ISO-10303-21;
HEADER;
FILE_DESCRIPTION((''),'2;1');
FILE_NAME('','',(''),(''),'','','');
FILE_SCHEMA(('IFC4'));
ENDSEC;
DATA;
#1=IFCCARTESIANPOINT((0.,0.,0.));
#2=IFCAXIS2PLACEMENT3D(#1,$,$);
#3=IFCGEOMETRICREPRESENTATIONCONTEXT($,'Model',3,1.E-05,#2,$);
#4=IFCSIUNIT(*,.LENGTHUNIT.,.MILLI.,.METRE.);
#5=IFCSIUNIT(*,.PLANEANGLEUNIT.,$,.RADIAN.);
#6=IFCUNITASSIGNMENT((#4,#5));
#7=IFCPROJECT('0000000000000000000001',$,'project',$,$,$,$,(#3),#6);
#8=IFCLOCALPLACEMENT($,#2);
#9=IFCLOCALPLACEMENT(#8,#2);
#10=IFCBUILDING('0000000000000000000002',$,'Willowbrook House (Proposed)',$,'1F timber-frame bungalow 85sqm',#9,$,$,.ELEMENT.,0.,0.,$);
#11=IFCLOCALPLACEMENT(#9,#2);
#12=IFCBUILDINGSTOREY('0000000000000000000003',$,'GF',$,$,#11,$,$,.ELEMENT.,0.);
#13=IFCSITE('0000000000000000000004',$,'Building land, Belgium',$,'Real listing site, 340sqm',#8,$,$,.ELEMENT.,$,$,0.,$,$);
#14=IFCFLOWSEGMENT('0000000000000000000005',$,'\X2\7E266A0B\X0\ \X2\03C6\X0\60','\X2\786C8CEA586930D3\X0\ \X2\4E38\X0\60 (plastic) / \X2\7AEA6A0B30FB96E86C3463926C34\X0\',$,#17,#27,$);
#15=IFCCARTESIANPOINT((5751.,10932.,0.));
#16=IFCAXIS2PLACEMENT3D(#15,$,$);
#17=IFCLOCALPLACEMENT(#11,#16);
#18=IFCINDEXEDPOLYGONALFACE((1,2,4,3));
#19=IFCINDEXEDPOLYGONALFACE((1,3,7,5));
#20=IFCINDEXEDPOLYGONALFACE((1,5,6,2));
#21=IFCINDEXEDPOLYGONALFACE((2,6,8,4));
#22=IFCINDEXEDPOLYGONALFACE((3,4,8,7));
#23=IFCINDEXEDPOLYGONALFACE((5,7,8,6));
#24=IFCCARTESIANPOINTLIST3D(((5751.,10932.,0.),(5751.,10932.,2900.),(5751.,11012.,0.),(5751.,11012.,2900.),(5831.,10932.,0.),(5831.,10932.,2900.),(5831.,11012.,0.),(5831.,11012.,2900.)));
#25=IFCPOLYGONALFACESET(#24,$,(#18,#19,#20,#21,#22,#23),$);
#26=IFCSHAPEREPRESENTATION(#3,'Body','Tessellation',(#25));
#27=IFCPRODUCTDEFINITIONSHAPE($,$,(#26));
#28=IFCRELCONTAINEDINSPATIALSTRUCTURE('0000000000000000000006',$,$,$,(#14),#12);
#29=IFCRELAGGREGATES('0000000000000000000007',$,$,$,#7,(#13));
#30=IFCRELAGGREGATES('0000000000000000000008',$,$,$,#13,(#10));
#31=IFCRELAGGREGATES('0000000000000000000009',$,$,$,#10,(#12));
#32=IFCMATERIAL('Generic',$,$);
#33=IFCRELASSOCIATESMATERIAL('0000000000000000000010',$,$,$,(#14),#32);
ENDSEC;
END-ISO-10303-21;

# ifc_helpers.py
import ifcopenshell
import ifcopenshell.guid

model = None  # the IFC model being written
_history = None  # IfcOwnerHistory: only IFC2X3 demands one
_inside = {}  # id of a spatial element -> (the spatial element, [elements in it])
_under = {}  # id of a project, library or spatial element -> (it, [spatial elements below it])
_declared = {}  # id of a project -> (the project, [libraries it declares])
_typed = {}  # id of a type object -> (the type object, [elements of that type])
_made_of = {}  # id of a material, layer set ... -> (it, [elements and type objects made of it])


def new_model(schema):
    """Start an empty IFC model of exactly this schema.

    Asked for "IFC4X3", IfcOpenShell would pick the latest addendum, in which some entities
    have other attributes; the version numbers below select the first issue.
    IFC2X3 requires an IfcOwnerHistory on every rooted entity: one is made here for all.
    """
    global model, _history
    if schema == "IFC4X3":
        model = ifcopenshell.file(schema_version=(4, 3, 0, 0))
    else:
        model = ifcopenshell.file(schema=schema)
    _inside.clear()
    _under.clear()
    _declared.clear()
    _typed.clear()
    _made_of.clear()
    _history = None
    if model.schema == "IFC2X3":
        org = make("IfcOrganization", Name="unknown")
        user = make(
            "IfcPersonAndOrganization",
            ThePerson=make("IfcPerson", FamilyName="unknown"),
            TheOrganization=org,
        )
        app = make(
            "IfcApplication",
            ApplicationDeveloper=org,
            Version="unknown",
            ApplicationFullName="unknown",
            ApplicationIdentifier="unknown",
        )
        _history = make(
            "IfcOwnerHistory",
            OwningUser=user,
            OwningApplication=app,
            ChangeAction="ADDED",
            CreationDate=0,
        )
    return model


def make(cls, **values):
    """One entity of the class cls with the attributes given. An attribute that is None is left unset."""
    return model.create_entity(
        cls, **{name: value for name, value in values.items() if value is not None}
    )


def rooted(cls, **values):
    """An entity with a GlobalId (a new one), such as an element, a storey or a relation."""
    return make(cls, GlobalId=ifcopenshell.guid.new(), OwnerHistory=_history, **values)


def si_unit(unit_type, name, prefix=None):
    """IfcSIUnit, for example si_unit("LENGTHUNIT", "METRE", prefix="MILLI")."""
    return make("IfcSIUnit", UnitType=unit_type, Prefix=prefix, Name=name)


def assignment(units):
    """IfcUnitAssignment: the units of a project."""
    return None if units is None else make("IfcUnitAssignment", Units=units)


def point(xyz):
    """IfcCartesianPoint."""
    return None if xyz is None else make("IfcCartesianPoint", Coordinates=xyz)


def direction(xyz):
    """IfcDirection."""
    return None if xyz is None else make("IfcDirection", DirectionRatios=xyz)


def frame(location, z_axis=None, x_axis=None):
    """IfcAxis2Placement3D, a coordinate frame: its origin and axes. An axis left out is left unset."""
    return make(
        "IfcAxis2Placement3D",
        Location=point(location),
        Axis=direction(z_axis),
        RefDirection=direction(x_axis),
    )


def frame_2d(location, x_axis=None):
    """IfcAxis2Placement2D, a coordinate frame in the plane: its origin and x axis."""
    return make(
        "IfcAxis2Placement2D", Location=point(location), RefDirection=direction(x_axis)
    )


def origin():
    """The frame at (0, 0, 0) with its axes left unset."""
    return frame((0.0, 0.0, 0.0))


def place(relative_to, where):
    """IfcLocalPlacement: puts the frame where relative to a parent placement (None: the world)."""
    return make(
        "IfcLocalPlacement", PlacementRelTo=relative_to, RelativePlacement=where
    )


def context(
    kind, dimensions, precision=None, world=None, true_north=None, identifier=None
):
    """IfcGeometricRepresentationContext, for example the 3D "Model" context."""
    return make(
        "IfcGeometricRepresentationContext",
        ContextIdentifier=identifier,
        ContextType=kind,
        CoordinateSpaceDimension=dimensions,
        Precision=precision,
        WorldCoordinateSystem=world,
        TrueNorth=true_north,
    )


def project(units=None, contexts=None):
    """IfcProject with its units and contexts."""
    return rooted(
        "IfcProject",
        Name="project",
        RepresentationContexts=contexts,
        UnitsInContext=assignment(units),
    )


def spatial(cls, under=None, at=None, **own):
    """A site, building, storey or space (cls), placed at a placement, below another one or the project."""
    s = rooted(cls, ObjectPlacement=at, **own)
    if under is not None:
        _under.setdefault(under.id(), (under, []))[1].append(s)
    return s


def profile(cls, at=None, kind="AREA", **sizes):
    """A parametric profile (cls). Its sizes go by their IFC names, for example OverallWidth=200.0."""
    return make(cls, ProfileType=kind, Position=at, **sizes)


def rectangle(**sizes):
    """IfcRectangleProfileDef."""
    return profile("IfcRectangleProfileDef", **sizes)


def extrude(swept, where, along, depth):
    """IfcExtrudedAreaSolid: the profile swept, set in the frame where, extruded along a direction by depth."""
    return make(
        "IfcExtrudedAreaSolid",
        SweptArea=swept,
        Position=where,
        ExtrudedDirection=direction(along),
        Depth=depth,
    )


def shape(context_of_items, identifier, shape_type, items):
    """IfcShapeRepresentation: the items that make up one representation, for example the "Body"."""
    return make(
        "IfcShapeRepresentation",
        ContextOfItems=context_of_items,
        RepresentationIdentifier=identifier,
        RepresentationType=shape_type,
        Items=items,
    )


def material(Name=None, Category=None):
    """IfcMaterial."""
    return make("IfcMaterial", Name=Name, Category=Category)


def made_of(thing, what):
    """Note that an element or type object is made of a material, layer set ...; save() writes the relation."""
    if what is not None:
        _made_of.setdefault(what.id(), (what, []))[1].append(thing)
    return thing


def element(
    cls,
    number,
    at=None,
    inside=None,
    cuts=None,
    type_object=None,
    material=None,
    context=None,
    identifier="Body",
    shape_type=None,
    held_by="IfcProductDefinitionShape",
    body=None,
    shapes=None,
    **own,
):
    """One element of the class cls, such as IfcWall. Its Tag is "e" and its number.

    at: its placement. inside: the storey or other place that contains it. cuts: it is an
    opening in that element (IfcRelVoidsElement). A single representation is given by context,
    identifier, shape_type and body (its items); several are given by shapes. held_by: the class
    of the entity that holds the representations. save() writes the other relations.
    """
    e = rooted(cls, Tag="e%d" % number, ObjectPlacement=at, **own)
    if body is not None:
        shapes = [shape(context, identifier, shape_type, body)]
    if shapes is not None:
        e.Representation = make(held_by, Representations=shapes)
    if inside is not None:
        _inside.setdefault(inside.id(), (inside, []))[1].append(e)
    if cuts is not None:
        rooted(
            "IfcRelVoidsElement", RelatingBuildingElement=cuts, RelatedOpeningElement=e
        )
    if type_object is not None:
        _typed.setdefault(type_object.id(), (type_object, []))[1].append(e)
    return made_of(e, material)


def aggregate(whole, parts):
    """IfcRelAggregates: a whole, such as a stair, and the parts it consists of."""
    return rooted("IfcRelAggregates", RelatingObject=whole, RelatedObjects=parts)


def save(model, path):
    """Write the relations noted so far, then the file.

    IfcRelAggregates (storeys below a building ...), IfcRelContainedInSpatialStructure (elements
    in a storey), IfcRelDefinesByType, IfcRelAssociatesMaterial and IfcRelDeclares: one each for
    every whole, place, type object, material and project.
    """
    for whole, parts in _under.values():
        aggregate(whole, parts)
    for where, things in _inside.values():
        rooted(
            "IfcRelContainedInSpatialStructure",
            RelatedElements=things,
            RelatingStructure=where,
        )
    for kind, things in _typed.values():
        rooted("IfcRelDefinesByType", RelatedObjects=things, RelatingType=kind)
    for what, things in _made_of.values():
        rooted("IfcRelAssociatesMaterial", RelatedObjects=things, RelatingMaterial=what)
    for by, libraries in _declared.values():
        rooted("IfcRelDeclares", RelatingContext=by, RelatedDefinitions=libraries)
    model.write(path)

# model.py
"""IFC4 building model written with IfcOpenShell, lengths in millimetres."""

from ifc_helpers import new_model, si_unit, frame, frame_2d, origin, place, context, project, spatial, rectangle, extrude, material, element, save


model = new_model("IFC4")

# Units and contexts
model_context = context("Model", 3, precision=1e-05, world=origin())
ifc_project = project(units=[si_unit("LENGTHUNIT", "METRE", prefix="MILLI"), si_unit("PLANEANGLEUNIT", "RADIAN")], contexts=[model_context])

# Site, building, storey
site_placement = place(None, origin())
site = spatial("IfcSite", under=ifc_project, at=site_placement, Name="Building land, Belgium", ObjectType="Real listing site, 340sqm", CompositionType="ELEMENT", RefElevation=0.0)
building_placement = place(site_placement, origin())
building = spatial("IfcBuilding", under=site, at=building_placement, Name="Willowbrook House (Proposed)", ObjectType="1F timber-frame bungalow 85sqm", CompositionType="ELEMENT", ElevationOfRefHeight=0.0, ElevationOfTerrain=0.0)
storey_placement = place(building_placement, origin())
storey = spatial("IfcBuildingStorey", under=building, at=storey_placement, Name="GF", CompositionType="ELEMENT", Elevation=0.0)

# Shared definitions
ifc_material_1 = material(Name="Generic")

# Flow segment
flow_segment_1_placement = place(storey_placement, frame((5751.0, 10932.0, 0.0)))
element("IfcFlowSegment", 1, at=flow_segment_1_placement, inside=storey, material=ifc_material_1, Name="縦樋 φ60", Description="硬質塩ビ 丸60 (plastic) / 竪樋・雨水排水", context=model_context, shape_type="SweptSolid", body=[
    extrude(rectangle(XDim=80.0, YDim=80.0, at=frame_2d((40.0, 40.0))), frame((5751.0, 10932.0, 0.0)), (0.0, 0.0, 1.0), 2900.0),
])

save(model, "model.ifc")
